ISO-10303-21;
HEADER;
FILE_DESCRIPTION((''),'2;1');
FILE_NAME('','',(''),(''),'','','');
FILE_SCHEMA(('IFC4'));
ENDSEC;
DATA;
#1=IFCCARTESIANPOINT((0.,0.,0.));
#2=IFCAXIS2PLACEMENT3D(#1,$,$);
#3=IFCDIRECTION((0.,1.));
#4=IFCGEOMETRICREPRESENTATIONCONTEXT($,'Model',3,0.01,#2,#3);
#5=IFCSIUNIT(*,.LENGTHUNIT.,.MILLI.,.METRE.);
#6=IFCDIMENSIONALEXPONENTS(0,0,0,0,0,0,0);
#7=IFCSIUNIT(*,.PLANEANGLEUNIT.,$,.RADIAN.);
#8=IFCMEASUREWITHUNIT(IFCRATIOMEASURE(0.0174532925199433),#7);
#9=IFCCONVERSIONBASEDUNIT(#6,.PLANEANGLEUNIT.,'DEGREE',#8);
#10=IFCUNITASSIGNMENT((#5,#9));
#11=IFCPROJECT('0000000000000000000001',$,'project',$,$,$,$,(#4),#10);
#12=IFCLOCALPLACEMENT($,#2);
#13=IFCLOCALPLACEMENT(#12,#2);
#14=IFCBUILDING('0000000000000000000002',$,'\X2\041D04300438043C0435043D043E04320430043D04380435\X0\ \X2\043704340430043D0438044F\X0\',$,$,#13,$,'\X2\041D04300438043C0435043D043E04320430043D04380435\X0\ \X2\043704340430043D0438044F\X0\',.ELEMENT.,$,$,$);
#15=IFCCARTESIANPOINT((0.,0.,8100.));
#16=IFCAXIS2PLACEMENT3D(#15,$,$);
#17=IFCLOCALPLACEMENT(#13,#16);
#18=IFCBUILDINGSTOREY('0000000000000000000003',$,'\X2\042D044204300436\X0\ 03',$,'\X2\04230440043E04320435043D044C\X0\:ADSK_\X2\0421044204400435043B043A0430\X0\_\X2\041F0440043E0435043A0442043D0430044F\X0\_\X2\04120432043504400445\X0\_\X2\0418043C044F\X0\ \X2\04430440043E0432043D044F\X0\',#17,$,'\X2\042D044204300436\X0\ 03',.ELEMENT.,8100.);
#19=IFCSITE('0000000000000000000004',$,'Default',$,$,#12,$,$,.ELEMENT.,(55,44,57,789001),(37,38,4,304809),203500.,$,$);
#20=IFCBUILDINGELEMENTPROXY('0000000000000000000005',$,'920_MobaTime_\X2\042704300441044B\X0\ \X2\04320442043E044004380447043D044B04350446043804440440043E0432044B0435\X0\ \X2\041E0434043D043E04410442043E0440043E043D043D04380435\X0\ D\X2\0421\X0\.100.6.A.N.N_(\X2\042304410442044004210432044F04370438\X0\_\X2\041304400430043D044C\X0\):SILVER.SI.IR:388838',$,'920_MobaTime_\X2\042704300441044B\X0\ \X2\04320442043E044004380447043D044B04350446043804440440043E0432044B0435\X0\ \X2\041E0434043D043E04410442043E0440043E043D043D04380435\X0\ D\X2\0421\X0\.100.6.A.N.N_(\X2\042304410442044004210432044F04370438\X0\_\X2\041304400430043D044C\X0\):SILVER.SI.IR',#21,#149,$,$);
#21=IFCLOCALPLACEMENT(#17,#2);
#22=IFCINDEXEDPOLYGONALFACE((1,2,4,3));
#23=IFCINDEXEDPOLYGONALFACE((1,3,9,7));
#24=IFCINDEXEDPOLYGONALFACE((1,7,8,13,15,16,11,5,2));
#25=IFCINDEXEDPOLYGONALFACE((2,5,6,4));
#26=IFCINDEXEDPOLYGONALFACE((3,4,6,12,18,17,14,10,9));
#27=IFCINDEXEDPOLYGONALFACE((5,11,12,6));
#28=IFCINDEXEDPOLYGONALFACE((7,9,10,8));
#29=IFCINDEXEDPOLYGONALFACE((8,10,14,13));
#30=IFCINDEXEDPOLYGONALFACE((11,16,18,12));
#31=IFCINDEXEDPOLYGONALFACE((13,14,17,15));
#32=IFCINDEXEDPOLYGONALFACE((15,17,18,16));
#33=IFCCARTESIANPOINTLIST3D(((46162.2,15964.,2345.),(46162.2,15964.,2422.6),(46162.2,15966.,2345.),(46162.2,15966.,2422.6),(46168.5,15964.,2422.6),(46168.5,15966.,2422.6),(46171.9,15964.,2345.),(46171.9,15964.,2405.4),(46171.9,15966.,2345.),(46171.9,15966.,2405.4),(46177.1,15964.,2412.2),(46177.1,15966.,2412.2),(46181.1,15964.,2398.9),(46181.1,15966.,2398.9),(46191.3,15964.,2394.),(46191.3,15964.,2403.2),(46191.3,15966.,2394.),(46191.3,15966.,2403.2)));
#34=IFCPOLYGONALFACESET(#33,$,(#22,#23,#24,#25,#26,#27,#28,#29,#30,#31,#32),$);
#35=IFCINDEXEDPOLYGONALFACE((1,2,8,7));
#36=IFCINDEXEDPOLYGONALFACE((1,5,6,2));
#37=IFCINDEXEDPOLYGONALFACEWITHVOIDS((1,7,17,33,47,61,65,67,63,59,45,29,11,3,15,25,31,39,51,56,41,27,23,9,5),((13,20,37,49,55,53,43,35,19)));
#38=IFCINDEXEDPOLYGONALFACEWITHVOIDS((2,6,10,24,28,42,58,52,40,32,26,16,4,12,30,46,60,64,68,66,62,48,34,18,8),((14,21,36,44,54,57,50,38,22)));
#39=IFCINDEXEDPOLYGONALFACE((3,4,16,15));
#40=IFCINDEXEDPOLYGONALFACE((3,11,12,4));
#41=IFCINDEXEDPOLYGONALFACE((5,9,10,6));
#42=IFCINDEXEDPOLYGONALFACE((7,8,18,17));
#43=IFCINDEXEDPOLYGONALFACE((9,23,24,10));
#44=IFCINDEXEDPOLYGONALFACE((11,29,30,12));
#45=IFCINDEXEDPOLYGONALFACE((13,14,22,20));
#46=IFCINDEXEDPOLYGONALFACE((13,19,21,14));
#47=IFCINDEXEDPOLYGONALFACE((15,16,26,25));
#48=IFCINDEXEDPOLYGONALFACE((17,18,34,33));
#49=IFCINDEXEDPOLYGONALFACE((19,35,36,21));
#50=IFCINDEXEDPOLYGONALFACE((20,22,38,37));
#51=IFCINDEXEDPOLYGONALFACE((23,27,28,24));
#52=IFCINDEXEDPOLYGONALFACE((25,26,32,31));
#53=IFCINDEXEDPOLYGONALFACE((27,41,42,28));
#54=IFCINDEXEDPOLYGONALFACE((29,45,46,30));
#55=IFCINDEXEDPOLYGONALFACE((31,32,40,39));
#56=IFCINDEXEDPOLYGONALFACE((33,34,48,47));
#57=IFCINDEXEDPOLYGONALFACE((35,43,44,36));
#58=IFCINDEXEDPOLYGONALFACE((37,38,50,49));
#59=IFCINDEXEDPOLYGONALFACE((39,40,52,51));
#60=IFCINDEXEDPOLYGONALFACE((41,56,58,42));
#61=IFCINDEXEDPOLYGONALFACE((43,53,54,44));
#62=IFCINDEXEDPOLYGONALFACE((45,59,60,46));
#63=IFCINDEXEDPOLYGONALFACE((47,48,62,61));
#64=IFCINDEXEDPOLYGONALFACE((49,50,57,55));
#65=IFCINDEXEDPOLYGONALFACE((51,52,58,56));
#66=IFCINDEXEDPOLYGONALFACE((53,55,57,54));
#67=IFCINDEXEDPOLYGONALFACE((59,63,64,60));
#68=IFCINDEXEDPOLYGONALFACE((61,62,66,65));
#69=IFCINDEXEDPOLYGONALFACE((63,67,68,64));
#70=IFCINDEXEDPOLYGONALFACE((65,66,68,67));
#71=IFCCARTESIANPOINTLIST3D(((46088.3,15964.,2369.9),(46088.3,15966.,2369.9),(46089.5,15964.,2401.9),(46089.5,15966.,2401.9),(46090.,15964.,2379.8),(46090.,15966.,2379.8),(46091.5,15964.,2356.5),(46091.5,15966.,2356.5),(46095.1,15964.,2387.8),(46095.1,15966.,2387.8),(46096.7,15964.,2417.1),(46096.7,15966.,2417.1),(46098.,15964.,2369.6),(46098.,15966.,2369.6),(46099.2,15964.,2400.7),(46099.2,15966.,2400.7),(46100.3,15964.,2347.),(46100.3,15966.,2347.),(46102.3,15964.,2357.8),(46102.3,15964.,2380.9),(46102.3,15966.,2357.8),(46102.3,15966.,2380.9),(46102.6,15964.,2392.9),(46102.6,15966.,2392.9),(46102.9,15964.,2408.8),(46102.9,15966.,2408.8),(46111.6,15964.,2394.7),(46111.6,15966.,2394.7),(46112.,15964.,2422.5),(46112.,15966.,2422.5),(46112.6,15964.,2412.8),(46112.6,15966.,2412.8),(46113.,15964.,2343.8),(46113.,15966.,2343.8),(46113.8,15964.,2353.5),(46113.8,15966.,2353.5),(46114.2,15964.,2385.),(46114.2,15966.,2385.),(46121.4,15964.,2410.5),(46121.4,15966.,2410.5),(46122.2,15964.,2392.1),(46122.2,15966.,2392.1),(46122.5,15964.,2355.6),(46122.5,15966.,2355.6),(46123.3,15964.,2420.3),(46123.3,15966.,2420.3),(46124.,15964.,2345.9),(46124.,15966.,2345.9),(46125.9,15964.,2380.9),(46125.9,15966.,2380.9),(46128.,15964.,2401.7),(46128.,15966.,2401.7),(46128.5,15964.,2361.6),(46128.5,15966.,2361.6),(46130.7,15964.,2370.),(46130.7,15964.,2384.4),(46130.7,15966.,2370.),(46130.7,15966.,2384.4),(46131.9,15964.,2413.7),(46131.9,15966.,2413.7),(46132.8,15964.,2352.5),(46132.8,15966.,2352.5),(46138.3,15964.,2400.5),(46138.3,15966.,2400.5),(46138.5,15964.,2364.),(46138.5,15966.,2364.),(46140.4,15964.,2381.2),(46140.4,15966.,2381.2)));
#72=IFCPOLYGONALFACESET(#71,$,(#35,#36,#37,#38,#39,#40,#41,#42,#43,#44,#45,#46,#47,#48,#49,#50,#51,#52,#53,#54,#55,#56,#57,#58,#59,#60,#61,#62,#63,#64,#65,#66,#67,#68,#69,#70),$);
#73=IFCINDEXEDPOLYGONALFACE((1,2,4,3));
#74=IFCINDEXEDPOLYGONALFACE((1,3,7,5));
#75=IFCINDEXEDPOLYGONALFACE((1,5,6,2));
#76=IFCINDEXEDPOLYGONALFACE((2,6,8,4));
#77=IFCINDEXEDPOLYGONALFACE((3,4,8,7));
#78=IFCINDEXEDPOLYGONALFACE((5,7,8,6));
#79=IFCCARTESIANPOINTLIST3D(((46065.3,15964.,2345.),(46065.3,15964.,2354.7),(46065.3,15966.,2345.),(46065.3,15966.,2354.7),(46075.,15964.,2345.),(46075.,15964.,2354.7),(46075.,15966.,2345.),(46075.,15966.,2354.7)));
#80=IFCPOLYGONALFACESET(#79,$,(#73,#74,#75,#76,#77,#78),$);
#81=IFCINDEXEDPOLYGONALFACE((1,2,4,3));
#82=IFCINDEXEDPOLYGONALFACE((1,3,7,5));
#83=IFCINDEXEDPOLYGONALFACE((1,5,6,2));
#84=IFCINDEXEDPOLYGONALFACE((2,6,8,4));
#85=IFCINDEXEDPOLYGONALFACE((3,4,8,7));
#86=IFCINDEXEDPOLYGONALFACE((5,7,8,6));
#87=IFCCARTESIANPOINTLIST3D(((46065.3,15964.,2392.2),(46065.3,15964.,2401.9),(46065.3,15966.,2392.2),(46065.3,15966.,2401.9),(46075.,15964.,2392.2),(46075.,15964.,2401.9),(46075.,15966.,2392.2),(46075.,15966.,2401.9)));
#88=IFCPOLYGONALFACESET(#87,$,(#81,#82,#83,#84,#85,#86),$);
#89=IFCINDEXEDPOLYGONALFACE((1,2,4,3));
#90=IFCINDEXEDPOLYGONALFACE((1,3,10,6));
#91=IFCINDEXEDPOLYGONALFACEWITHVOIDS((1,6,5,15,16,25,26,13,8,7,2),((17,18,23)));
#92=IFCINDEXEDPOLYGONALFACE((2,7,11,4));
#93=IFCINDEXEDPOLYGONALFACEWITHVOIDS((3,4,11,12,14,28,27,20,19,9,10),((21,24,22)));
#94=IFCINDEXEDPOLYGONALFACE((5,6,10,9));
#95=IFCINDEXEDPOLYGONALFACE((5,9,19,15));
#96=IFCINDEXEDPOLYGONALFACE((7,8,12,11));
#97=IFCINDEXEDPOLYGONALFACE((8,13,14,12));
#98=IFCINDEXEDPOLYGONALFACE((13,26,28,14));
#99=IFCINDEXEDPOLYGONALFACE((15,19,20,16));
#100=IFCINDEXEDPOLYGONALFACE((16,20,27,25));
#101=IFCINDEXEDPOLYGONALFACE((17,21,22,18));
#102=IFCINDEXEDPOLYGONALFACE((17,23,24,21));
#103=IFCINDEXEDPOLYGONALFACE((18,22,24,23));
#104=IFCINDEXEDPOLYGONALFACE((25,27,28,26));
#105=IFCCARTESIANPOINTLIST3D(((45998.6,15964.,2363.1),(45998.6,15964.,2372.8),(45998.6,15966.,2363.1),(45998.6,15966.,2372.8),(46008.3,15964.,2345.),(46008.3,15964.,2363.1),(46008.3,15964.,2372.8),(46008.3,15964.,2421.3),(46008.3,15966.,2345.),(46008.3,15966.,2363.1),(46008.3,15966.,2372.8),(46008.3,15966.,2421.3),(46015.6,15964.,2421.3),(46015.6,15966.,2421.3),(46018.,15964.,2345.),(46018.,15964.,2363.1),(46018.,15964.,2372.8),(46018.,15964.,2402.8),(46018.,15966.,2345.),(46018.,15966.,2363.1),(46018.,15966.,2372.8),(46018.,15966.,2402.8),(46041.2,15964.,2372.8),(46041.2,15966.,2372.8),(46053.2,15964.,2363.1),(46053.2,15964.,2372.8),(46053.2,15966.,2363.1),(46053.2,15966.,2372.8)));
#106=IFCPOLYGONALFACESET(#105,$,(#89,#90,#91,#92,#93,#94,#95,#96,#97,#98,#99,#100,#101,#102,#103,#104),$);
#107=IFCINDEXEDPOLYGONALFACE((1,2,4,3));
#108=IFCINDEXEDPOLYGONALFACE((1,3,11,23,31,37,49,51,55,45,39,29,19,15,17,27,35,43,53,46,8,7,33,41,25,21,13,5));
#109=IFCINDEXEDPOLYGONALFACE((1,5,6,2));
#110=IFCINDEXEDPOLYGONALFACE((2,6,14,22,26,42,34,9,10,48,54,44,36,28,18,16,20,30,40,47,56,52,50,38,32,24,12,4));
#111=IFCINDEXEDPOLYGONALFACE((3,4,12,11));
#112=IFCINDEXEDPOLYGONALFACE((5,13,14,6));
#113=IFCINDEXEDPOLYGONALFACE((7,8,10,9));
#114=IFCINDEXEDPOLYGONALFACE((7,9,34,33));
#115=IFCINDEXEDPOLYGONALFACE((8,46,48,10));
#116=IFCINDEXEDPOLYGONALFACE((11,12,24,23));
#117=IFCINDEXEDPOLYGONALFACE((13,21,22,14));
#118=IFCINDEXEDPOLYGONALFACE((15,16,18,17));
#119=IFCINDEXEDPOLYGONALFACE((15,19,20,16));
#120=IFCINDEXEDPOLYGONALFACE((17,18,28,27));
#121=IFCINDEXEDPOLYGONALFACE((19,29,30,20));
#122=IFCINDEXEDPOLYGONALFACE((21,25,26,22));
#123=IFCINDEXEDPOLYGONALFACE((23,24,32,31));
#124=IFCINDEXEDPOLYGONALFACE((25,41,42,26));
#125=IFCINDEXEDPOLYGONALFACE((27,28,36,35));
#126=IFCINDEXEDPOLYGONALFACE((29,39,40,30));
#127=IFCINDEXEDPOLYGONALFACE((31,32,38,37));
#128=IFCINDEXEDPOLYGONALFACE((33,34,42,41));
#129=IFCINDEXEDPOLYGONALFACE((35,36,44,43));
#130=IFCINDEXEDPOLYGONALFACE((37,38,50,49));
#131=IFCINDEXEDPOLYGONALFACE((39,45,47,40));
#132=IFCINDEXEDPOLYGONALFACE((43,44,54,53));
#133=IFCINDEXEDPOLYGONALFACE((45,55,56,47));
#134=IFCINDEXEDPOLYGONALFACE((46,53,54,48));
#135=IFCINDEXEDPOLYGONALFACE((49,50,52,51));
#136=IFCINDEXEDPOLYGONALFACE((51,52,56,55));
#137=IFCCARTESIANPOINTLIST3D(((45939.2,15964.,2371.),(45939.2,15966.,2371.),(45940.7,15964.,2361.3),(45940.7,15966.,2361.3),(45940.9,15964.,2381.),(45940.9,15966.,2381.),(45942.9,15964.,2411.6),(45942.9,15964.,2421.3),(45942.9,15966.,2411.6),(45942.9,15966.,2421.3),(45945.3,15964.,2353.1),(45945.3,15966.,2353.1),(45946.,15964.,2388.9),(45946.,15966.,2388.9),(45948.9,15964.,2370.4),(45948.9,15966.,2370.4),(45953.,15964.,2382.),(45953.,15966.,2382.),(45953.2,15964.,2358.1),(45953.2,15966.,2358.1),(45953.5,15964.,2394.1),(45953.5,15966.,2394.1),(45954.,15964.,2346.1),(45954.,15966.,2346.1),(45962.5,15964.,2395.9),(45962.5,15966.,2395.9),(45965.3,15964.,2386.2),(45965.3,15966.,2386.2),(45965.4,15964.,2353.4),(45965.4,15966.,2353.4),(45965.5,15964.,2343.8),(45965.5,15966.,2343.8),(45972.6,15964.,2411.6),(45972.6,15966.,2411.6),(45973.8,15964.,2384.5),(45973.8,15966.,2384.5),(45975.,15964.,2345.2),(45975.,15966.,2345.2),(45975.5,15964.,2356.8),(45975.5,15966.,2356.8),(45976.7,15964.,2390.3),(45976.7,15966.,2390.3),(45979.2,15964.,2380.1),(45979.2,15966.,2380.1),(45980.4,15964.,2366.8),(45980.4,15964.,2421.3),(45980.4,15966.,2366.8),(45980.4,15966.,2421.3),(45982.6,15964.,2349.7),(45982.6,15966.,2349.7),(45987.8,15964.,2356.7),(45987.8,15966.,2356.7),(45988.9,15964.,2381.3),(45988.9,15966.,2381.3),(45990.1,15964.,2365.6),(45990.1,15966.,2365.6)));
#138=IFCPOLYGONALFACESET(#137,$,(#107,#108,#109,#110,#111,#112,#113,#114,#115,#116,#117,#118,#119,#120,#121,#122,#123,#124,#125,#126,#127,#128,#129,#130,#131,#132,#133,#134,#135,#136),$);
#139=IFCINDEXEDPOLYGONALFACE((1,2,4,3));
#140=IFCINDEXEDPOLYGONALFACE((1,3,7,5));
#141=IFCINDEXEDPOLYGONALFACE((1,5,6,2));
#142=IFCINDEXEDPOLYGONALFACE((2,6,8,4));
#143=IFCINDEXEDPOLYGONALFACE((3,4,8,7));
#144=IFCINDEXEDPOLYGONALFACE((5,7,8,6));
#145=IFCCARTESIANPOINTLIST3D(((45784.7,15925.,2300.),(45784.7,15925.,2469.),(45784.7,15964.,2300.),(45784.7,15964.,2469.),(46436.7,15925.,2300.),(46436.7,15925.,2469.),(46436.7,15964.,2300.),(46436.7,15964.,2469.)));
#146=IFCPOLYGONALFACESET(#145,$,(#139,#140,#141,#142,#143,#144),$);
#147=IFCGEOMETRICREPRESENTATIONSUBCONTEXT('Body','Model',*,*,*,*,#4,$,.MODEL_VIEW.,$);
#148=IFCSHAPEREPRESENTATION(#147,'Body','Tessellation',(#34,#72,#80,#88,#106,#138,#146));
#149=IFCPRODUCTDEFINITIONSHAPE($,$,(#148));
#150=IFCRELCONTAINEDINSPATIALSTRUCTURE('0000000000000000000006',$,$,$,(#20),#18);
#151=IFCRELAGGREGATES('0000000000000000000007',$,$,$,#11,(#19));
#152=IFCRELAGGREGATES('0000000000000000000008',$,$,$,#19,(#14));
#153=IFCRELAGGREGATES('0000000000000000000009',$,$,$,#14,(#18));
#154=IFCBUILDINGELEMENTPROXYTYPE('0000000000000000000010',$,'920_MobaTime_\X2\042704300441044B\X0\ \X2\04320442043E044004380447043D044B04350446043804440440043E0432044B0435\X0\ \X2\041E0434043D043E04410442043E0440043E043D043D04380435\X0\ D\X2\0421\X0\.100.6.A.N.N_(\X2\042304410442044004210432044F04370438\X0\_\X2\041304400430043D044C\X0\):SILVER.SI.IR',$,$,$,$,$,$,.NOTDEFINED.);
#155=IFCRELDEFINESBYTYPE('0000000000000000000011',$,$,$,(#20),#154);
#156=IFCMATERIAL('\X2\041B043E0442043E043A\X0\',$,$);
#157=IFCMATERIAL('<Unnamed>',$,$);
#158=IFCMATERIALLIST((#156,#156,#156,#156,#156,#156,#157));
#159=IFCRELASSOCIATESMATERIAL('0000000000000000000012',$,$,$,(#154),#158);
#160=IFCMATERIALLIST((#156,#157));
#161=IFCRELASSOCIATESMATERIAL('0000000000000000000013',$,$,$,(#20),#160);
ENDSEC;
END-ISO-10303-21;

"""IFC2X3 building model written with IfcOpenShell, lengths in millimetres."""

from ifc_helpers import new_model, entity, si_unit, converted_unit, direction, frame, origin, origin_2d_with_axis, place, context, subcontext, project, spatial, polyline, rectangle, outline, extrude, source, transform, mapped, material, material_list, type_object, type_shapes, element, save


model = new_model("IFC2X3")

# Units and contexts
model_context = context("Model", 3, precision=0.01, world=origin(), true_north=direction((0.0, 1.0)))
body_context = subcontext(model_context, "Body", "Model", "MODEL_VIEW")
ifc_project = project(units=[si_unit("LENGTHUNIT", "METRE", prefix="MILLI"), converted_unit("PLANEANGLEUNIT", "DEGREE", entity("IfcRatioMeasure", 0.0174532925199433), si_unit("PLANEANGLEUNIT", "RADIAN"), dimensions=[0, 0, 0, 0, 0, 0, 0])], contexts=[model_context])

# Site, building, storey
site_placement = place(None, origin())
site = spatial("IfcSite", under=ifc_project, at=site_placement, Name="Default", CompositionType="ELEMENT", RefLatitude=(55, 44, 57, 789001), RefLongitude=(37, 38, 4, 304809), RefElevation=203500.0)
building_placement = place(site_placement, origin())
building = spatial("IfcBuilding", under=site, at=building_placement, Name="Наименование здания", LongName="Наименование здания", CompositionType="ELEMENT")
storey_placement = place(building_placement, frame((0.0, 0.0, 8100.0)))
storey = spatial("IfcBuildingStorey", under=building, at=storey_placement, Name="Этаж 03", ObjectType="Уровень:ADSK_Стрелка_Проектная_Вверх_Имя уровня", LongName="Этаж 03", CompositionType="ELEMENT", Elevation=8100.0)

# Building element proxy
ifc_material_1 = material(Name="Лоток")
ifc_material_2 = material(Name="<Unnamed>")
ifc_material_list_1 = material_list([ifc_material_1, ifc_material_1, ifc_material_1, ifc_material_1, ifc_material_1, ifc_material_1, ifc_material_2])
building_element_proxy_type = type_object("IfcBuildingElementProxyType", Name="920_MobaTime_Часы вторичныецифровые Односторонние DС.100.6.A.N.N_(УстрСвязи_Грань):SILVER.SI.IR", PredefinedType="NOTDEFINED", material=ifc_material_list_1)
shared_shape = source(origin(), body_context, "Body", "SweptSolid", [
    extrude(outline(polyline([(-49.3, -13.1), (28.2, -13.1), (28.2, -6.8), (17.9, 1.8), (8.8, 16.0), (-0.3, 16.0), (4.6, 5.8), (11.1, -3.4), (-49.3, -3.4), (-49.3, -13.1)])), frame((-64.6, 9.8, 39.0), z_axis=(0.0, 0.0, 1.0), x_axis=(0.0, 1.0, 0.0)), (0.0, 0.0, 1.0), 2.0),
    extrude(outline(polyline([(2.2, -27.6), (19.0, -27.6), (30.5, -16.1), (33.3, -4.9), (31.0, 5.8), (21.8, 17.2), (5.2, 27.3), (-11.1, 33.0), (-24.0, 32.7), (-33.6, 27.6), (-40.3, 18.6), (-42.8, 5.7), (-38.0, -6.3), (-27.2, -14.9), (-17.5, -17.7), (-8.2, -16.4), (-0.3, -11.9), (5.1, -4.5), (7.3, 6.2), (4.0, 17.2), (18.4, 7.3), (23.6, -2.4), (22.0, -11.4), (14.2, -18.4), (5.3, -18.3), (2.2, -27.6)]), holes=[polyline([(-9.0, 23.3), (-1.3, 14.3), (-2.5, 2.0), (-11.4, -7.0), (-23.4, -6.0), (-32.2, 2.9), (-31.2, 15.1), (-25.6, 22.1), (-17.5, 24.9), (-9.0, 23.3)])]), frame((-2.7, 3.6, 39.0), z_axis=(0.0, 0.0, 1.0), x_axis=(-0.427649, 0.903945, 0.0)), (0.0, 0.0, 1.0), 2.0),
    extrude(rectangle(XDim=9.7, YDim=9.7, at=origin_2d_with_axis()), frame((40.6, -34.7, 39.0)), (0.0, 0.0, 1.0), 2.0),
    extrude(rectangle(XDim=9.7, YDim=9.7, at=origin_2d_with_axis()), frame((40.6, 12.6, 39.0)), (0.0, 0.0, 1.0), 2.0),
    extrude(outline(polyline([(-0.9, -28.1), (8.8, -28.1), (8.8, -9.9), (18.5, -9.9), (18.5, -0.2), (8.8, -0.2), (8.8, 48.3), (1.5, 48.3), (-36.0, -0.2), (-36.0, -9.9), (-0.9, -9.9), (-0.9, -28.1)]), holes=[polyline([(-0.9, -0.2), (-24.1, -0.2), (-0.9, 29.7), (-0.9, -0.2)])]), frame((93.6, -11.4, 39.0)), (0.0, 0.0, 1.0), 2.0),
    extrude(outline(polyline([(3.3, -28.3), (12.5, -28.3), (20.5, -25.0), (26.8, -18.9), (30.7, -10.0), (31.4, 1.6), (26.9, 11.8), (20.1, 18.4), (11.1, 22.3), (1.0, 23.3), (-7.9, 20.4), (-14.9, 14.5), (-18.9, 6.2), (-17.1, -9.0), (-36.7, 0.5), (-29.1, 29.2), (-38.5, 31.7), (-48.1, -4.6), (-11.6, -23.1), (-8.0, -14.0), (-10.8, -7.6), (-10.2, 1.1), (-3.0, 11.8), (9.2, 12.8), (20.0, 5.5), (21.4, -7.5), (15.5, -16.4), (4.6, -18.6), (3.3, -28.3)])), frame((147.1, -8.5, 39.0), z_axis=(0.0, 0.0, 1.0), x_axis=(0.256974, -0.966418, 0.0)), (0.0, 0.0, 1.0), 2.0),
    extrude(rectangle(XDim=652.0, YDim=169.0, at=origin_2d_with_axis()), frame((0.0, 0.0, 0.0), z_axis=(0.0, 0.0, 1.0), x_axis=(-1.0, 0.0, 0.0)), (0.0, 0.0, 1.0), 39.0),
])
type_shapes(building_element_proxy_type, [shared_shape])
ifc_material_list_2 = material_list([ifc_material_1, ifc_material_2])
for number, where, z_axis, x_axis, name in (
    (1, (46110.7, 15925.0, 2384.5), (0.0, 1.0, 0.0), (-1.0, 0.0, 0.0), "920_MobaTime_Часы вторичныецифровые Односторонние DС.100.6.A.N.N_(УстрСвязи_Грань):SILVER.SI.IR:388838"),
):
    element("IfcBuildingElementProxy", number, at=place(storey_placement, frame(where, z_axis=z_axis, x_axis=x_axis)), inside=storey, type_object=building_element_proxy_type, material=ifc_material_list_2, Name=name, ObjectType="920_MobaTime_Часы вторичныецифровые Односторонние DС.100.6.A.N.N_(УстрСвязи_Грань):SILVER.SI.IR", context=body_context, shape_type="MappedRepresentation", body=[
        mapped(shared_shape, transform((0.0, 0.0, 0.0), scale=1.0)),
    ])

save(model, "model.ifc")
